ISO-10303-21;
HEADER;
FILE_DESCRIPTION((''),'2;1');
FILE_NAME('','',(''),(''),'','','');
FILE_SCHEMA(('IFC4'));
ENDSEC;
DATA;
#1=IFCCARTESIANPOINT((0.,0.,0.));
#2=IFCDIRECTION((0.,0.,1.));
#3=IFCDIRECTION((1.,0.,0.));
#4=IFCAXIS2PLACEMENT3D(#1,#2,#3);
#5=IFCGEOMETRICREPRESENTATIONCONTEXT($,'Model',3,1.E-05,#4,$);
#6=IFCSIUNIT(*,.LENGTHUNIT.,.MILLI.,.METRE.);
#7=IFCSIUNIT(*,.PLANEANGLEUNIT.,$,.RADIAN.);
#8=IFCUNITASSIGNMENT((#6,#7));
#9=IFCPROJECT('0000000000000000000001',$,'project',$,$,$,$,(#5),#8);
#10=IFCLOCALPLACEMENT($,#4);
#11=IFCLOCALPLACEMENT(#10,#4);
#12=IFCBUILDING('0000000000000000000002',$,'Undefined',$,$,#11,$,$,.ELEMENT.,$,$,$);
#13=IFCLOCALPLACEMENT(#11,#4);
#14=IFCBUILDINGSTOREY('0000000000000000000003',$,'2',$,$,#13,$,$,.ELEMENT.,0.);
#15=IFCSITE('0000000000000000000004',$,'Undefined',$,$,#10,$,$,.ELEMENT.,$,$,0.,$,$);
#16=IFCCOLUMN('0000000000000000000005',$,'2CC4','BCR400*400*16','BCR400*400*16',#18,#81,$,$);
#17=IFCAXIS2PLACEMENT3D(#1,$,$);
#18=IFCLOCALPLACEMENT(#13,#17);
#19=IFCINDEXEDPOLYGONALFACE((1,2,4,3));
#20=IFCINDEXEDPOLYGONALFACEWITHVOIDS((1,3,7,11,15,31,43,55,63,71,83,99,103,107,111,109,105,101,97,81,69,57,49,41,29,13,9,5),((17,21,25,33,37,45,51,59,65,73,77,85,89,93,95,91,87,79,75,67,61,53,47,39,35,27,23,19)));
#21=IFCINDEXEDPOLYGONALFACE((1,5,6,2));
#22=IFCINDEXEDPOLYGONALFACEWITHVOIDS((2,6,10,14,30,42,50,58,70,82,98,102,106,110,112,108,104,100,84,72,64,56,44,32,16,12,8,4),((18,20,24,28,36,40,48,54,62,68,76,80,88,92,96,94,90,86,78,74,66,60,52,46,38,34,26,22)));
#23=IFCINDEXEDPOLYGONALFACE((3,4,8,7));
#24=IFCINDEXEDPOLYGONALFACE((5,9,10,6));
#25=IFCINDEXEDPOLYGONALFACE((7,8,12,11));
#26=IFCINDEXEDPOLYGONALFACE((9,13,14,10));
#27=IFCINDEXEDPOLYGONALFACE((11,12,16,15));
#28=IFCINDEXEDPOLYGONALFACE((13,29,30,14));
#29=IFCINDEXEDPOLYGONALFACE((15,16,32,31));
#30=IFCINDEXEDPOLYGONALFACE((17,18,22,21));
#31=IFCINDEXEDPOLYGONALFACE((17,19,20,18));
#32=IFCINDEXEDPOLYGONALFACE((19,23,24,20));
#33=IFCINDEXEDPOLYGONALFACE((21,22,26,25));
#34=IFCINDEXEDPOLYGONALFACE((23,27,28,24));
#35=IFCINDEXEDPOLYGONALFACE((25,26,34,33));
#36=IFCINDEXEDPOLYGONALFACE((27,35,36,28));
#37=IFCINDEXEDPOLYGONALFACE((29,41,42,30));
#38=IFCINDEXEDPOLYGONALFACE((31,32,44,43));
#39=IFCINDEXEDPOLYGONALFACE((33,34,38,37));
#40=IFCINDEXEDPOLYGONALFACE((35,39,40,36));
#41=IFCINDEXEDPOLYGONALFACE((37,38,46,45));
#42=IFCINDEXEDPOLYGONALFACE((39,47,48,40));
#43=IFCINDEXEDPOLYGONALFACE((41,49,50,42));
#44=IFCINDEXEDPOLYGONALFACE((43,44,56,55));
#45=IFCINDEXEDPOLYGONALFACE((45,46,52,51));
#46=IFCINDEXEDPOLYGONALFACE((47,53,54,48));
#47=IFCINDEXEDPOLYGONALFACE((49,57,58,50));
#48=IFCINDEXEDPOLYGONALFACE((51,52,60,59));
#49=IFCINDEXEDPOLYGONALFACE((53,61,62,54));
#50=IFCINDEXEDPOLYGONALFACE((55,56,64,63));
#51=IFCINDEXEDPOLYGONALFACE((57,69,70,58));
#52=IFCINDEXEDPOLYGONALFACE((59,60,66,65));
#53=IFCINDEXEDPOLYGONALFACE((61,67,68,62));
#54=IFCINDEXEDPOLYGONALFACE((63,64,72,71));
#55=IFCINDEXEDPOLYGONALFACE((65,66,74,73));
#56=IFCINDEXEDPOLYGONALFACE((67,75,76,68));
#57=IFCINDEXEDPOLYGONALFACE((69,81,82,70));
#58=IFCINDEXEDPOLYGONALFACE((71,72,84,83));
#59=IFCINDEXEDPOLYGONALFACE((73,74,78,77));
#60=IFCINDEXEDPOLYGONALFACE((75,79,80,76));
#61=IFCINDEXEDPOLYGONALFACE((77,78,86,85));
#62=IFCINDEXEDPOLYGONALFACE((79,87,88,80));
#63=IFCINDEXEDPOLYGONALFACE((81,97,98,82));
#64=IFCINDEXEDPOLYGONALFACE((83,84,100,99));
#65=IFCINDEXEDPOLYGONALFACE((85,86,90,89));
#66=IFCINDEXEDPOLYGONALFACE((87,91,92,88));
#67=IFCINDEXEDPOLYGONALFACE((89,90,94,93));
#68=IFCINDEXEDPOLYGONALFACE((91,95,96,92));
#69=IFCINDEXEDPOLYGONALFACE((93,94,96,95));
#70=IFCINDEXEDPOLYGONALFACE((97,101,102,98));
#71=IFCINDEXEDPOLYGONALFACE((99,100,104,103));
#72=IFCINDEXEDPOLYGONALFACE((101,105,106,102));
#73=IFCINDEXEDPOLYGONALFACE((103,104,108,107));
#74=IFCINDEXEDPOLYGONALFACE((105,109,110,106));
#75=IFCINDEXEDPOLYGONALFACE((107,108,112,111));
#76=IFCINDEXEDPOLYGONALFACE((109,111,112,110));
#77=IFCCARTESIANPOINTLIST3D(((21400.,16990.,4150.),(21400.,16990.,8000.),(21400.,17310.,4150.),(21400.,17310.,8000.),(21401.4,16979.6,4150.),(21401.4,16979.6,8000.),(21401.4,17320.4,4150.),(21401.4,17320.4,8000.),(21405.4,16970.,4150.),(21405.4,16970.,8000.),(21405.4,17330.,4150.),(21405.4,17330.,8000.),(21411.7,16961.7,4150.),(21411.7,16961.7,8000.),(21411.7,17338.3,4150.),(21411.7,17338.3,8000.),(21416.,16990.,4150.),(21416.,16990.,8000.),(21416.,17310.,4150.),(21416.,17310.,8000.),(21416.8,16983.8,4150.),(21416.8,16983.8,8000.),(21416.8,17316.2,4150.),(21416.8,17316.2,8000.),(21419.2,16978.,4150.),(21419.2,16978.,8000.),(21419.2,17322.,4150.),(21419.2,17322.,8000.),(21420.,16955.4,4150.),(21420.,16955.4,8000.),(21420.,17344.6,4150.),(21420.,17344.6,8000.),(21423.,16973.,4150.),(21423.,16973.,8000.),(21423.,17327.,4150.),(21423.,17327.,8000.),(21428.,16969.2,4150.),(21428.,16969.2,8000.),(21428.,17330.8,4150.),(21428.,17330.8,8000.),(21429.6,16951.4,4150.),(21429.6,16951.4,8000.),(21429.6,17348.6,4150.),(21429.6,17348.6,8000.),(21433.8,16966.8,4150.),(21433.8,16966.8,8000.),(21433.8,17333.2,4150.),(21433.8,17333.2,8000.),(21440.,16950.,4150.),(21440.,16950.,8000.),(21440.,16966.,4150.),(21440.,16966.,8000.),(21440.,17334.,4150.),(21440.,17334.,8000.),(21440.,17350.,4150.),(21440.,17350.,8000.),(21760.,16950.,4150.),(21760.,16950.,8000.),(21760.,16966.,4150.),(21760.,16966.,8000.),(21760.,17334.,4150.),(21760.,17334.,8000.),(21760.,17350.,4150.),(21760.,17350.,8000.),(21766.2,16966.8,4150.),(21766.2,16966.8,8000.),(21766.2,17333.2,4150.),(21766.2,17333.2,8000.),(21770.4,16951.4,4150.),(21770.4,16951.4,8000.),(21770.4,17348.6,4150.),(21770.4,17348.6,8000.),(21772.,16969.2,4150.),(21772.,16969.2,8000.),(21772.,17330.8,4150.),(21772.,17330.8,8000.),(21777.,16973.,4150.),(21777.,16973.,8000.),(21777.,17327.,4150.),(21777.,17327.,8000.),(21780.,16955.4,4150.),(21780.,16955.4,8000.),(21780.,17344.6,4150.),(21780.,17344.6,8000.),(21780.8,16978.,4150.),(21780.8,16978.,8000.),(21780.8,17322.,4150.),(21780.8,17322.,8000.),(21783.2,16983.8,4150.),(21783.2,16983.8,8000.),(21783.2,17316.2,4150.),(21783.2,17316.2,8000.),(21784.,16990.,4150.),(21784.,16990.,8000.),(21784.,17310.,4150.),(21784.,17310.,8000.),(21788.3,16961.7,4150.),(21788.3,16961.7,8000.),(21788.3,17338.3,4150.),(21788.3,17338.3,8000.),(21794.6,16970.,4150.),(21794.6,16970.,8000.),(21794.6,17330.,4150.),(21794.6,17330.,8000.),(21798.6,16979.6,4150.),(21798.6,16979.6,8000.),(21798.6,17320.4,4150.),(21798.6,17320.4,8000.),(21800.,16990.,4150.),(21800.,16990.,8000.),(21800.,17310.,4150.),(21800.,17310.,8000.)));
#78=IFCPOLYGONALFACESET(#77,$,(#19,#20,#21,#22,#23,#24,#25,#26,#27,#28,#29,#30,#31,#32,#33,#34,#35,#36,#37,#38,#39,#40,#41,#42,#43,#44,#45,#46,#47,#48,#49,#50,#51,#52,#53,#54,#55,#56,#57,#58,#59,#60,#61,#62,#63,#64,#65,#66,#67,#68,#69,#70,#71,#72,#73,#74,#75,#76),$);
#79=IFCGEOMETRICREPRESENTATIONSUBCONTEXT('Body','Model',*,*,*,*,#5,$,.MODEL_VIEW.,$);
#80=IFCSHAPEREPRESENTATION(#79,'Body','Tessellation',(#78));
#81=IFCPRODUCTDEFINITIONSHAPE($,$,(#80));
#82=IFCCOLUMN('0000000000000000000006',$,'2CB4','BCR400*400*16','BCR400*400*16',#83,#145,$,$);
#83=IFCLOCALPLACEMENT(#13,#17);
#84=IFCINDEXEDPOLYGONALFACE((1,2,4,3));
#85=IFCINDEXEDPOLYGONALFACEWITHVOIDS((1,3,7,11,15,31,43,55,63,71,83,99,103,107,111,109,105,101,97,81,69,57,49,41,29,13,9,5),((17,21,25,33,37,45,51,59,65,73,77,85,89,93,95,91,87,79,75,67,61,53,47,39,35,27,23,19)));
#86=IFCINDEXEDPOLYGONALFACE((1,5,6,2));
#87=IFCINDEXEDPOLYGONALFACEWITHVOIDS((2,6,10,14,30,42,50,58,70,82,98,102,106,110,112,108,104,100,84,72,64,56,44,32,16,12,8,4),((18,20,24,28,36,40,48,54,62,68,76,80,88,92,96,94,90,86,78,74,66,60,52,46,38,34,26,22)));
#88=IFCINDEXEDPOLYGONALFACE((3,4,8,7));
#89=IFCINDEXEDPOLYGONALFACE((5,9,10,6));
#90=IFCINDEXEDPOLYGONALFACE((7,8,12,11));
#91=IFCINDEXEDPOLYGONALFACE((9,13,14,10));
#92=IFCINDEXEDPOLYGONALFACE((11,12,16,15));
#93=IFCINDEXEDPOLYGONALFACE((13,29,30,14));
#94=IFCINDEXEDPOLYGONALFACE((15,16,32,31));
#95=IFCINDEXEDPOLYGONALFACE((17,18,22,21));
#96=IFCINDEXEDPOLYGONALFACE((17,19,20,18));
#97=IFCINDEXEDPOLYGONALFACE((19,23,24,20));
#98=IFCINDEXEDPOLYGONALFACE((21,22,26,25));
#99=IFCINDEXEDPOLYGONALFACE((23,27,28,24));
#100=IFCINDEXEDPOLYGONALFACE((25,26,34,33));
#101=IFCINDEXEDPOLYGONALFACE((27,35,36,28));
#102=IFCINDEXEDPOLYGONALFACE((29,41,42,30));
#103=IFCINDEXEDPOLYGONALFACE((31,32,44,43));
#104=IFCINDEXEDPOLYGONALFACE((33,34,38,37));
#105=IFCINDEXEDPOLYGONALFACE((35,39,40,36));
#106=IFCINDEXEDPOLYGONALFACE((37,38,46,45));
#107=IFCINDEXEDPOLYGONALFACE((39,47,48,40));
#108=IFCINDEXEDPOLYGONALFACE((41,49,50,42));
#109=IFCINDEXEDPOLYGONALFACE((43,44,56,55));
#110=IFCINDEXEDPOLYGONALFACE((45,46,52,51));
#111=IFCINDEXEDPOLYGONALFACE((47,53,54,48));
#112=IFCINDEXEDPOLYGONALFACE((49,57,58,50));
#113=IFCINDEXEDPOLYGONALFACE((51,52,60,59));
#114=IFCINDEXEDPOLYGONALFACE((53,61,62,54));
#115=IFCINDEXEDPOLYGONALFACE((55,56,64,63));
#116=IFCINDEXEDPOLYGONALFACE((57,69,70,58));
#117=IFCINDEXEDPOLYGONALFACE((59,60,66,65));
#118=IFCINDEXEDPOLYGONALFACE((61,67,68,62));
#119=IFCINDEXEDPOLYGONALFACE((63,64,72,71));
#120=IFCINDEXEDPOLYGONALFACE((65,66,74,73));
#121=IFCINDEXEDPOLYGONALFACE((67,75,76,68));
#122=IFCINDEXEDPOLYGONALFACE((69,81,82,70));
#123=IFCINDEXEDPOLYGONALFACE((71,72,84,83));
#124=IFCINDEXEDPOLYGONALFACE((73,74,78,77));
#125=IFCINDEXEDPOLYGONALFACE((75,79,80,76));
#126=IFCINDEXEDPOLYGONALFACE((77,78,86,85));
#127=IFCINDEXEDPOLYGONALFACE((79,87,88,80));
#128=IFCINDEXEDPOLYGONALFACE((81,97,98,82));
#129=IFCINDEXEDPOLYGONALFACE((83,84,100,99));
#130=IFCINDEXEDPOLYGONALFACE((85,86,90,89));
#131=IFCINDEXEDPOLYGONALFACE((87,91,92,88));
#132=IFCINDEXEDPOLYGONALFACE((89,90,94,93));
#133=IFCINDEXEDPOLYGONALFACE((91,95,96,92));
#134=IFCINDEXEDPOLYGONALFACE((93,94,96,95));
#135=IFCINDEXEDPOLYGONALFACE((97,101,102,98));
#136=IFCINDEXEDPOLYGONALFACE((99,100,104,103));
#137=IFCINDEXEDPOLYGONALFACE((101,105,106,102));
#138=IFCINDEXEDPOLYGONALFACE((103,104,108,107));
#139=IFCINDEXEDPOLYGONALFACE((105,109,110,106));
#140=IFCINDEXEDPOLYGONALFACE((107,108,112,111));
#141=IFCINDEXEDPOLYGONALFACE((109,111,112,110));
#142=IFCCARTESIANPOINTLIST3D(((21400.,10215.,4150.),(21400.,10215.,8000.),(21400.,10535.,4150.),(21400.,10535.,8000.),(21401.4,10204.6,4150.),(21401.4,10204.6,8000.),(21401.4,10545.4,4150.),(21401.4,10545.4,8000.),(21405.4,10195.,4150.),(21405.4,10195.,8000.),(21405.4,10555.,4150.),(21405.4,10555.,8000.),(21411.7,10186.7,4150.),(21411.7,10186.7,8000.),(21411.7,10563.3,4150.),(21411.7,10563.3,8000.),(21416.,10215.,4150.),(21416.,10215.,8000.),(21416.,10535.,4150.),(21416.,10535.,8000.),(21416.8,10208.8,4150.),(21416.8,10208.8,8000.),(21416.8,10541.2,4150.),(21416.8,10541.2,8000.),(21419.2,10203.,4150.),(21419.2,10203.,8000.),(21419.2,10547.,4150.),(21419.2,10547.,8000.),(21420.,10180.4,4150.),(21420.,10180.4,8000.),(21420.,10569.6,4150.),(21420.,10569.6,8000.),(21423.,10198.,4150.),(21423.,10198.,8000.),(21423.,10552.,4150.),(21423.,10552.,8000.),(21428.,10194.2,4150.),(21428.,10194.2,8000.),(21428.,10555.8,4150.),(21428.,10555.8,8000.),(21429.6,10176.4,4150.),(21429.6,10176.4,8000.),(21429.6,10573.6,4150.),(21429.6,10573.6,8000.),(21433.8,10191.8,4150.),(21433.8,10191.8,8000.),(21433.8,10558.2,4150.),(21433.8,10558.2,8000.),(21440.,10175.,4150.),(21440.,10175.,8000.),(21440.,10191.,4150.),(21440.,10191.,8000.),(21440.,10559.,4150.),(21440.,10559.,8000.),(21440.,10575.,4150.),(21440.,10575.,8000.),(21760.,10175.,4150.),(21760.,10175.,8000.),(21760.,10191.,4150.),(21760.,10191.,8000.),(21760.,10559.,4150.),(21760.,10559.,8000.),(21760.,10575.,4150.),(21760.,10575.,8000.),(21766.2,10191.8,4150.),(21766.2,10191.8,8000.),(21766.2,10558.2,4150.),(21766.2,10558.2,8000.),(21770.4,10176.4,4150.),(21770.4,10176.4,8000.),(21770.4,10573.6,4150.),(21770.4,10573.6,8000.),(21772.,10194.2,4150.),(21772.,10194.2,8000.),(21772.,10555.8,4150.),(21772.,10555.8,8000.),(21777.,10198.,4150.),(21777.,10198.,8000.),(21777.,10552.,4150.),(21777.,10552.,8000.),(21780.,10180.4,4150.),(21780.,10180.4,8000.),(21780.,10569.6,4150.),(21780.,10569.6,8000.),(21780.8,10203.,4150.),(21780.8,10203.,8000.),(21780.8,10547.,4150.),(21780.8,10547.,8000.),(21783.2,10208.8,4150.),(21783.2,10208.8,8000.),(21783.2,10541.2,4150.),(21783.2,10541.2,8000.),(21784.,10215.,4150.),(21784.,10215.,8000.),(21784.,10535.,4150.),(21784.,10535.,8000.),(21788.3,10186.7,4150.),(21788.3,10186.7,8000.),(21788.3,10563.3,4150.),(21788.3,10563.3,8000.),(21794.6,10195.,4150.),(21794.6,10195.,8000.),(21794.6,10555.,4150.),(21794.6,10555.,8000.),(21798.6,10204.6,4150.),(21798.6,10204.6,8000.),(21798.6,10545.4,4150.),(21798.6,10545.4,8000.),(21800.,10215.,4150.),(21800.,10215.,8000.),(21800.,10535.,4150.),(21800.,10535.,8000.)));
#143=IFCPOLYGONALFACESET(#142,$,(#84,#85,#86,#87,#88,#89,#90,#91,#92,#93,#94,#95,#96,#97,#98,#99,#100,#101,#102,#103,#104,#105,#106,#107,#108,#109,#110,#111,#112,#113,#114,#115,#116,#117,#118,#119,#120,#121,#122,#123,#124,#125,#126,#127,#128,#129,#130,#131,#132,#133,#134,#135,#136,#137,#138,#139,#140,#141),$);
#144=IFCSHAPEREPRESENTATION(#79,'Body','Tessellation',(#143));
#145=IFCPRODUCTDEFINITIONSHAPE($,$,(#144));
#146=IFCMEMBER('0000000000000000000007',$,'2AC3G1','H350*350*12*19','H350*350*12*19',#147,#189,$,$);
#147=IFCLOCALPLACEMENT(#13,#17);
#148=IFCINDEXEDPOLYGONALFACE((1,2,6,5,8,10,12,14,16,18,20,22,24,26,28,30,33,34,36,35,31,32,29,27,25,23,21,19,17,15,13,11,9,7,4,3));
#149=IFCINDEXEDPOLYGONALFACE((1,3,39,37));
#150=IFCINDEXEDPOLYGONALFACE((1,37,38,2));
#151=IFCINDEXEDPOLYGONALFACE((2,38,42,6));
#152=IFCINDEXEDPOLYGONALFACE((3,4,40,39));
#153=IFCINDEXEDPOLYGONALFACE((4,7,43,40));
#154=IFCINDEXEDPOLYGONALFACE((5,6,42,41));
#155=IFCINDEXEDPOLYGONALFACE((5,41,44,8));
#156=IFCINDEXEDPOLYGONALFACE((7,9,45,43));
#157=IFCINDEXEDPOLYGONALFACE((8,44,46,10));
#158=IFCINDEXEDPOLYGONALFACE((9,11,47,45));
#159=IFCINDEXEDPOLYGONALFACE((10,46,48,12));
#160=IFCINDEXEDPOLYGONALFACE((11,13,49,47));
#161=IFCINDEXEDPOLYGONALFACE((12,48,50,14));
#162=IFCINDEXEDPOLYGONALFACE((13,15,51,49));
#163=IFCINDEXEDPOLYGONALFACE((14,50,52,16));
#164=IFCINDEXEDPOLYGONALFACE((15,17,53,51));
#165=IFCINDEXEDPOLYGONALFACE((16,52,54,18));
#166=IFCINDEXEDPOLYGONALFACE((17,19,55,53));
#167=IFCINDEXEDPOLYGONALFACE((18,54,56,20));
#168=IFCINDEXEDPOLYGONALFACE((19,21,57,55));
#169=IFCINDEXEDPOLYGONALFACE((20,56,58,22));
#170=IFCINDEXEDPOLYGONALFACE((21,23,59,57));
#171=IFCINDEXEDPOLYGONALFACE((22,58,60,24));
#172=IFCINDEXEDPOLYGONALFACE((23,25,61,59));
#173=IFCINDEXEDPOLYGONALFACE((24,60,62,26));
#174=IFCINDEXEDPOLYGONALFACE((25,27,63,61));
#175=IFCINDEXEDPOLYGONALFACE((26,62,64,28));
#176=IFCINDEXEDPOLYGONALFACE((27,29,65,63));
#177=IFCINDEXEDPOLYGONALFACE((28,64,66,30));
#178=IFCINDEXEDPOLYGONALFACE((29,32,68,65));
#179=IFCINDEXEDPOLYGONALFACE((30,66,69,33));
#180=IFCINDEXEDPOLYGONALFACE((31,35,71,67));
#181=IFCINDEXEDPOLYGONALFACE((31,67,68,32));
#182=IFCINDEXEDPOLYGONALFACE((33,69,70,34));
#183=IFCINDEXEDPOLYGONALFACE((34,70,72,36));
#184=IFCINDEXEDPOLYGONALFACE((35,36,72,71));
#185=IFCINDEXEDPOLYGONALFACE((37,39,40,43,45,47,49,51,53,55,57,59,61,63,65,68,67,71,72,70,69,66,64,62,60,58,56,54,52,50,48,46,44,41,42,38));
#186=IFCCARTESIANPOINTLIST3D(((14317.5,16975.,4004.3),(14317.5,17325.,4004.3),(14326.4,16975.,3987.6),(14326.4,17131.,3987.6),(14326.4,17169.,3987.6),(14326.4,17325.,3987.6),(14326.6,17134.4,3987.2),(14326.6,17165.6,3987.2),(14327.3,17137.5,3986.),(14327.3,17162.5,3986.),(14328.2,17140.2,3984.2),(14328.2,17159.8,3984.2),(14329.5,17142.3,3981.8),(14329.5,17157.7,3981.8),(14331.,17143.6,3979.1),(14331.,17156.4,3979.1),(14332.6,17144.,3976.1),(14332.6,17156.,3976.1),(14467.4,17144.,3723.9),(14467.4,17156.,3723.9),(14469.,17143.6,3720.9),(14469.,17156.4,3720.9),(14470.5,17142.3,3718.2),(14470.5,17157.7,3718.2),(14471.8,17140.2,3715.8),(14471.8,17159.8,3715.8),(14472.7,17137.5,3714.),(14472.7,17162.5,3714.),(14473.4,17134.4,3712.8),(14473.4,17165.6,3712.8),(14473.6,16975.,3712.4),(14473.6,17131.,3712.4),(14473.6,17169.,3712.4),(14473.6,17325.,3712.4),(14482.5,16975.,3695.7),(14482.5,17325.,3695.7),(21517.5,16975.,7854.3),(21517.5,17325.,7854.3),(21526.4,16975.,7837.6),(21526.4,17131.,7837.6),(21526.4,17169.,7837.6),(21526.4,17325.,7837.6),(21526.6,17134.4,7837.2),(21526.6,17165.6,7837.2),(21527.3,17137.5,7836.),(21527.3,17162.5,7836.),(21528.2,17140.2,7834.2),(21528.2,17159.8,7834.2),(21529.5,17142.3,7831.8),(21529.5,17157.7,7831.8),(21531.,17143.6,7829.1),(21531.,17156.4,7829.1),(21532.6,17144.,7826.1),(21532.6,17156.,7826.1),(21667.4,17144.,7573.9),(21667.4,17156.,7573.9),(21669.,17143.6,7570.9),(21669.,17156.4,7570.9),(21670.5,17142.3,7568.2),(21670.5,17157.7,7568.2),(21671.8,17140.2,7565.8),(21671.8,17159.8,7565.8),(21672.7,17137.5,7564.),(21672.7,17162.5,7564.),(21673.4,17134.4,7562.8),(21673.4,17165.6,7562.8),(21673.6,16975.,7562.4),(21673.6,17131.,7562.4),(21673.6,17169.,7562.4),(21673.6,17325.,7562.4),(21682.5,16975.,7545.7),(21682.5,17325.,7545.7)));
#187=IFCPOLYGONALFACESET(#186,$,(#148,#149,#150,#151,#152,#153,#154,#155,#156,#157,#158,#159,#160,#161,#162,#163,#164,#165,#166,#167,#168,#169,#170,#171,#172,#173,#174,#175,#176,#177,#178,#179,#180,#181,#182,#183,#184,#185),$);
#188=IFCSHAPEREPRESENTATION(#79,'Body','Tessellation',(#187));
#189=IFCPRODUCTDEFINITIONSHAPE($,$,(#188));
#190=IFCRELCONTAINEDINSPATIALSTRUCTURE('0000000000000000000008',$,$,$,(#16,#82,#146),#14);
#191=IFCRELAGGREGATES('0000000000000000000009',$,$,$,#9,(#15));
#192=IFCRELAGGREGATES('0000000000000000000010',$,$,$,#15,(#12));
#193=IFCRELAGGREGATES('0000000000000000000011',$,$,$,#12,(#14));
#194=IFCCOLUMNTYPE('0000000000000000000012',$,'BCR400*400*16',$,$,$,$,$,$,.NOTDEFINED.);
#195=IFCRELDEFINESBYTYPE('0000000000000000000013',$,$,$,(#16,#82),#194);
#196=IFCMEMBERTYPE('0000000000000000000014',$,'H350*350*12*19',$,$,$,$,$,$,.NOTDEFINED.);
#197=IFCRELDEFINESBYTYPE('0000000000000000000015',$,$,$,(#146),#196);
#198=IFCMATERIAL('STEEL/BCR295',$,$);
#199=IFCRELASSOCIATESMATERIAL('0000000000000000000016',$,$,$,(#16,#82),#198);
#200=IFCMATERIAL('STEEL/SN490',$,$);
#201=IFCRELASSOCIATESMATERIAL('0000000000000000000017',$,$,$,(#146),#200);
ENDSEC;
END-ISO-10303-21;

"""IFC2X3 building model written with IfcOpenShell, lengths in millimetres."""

from ifc_helpers import new_model, si_unit, frame, origin_with_axes, origin_2d_with_axis, place, context, subcontext, project, spatial, hollow_rectangle, i_section, extrude, material, type_object, element, save


model = new_model("IFC2X3")

# Units and contexts
model_context = context("Model", 3, precision=1e-05, world=origin_with_axes())
body_context = subcontext(model_context, "Body", "Model", "MODEL_VIEW")
ifc_project = project(units=[si_unit("LENGTHUNIT", "METRE", prefix="MILLI"), si_unit("PLANEANGLEUNIT", "RADIAN")], contexts=[model_context])

# Site, building, storey
site_placement = place(None, origin_with_axes())
site = spatial("IfcSite", under=ifc_project, at=site_placement, Name="Undefined", CompositionType="ELEMENT", RefElevation=0.0)
building_placement = place(site_placement, origin_with_axes())
building = spatial("IfcBuilding", under=site, at=building_placement, Name="Undefined", CompositionType="ELEMENT")
storey_placement = place(building_placement, origin_with_axes())
storey = spatial("IfcBuildingStorey", under=building, at=storey_placement, Name="2", CompositionType="ELEMENT", Elevation=0.0)

# Columns
ifc_material_1 = material(Name="STEEL/SN490")
ifc_material_2 = material(Name="STEEL/BCR295")
column_type_1 = type_object("IfcColumnType", Name="BCR400*400*16", PredefinedType="NOTDEFINED")
for number, where, z_axis, x_axis, name in (
    (1, (21600.0, 17150.0, 4150.0), (0.0, 0.0, 1.0), (0.0, 1.0, 0.0), "2CC4"),
    (2, (21600.0, 10375.0, 4150.0), (0.0, 0.0, 1.0), (0.0, 1.0, 0.0), "2CB4"),
):
    element("IfcColumn", number, at=place(storey_placement, frame(where, z_axis=z_axis, x_axis=x_axis)), inside=storey, type_object=column_type_1, material=ifc_material_2, Name=name, Description="BCR400*400*16", ObjectType="BCR400*400*16", context=body_context, shape_type="SweptSolid", body=[
        extrude(hollow_rectangle(XDim=400.0, YDim=400.0, WallThickness=16.0, InnerFilletRadius=24.0, OuterFilletRadius=40.0, at=origin_2d_with_axis()), frame((0.0, 0.0, 3850.0), z_axis=(0.0, 0.0, -1.0), x_axis=(0.0, 1.0, 0.0)), (0.0, 0.0, 1.0), 3850.0),
    ])

# Member
member_type = type_object("IfcMemberType", Name="H350*350*12*19", PredefinedType="NOTDEFINED")
member_placement = place(storey_placement, frame((14400.0, 17150.0, 3850.0), z_axis=(-0.471542, 0.0, 0.881844), x_axis=(0.881844, 0.0, 0.471542)))
element("IfcMember", 3, at=member_placement, inside=storey, type_object=member_type, material=ifc_material_1, Name="2AC3G1", Description="H350*350*12*19", ObjectType="H350*350*12*19", context=body_context, shape_type="SweptSolid", body=[
    extrude(i_section(OverallWidth=350.0, OverallDepth=350.0, WebThickness=12.0, FlangeThickness=19.0, FilletRadius=13.0, at=origin_2d_with_axis()), frame((8164.7, 0.0, 0.0), z_axis=(-1.0, 0.0, 0.0), x_axis=(0.0, -1.0, 0.0)), (0.0, 0.0, 1.0), 8164.7),
])

save(model, "model.ifc")
